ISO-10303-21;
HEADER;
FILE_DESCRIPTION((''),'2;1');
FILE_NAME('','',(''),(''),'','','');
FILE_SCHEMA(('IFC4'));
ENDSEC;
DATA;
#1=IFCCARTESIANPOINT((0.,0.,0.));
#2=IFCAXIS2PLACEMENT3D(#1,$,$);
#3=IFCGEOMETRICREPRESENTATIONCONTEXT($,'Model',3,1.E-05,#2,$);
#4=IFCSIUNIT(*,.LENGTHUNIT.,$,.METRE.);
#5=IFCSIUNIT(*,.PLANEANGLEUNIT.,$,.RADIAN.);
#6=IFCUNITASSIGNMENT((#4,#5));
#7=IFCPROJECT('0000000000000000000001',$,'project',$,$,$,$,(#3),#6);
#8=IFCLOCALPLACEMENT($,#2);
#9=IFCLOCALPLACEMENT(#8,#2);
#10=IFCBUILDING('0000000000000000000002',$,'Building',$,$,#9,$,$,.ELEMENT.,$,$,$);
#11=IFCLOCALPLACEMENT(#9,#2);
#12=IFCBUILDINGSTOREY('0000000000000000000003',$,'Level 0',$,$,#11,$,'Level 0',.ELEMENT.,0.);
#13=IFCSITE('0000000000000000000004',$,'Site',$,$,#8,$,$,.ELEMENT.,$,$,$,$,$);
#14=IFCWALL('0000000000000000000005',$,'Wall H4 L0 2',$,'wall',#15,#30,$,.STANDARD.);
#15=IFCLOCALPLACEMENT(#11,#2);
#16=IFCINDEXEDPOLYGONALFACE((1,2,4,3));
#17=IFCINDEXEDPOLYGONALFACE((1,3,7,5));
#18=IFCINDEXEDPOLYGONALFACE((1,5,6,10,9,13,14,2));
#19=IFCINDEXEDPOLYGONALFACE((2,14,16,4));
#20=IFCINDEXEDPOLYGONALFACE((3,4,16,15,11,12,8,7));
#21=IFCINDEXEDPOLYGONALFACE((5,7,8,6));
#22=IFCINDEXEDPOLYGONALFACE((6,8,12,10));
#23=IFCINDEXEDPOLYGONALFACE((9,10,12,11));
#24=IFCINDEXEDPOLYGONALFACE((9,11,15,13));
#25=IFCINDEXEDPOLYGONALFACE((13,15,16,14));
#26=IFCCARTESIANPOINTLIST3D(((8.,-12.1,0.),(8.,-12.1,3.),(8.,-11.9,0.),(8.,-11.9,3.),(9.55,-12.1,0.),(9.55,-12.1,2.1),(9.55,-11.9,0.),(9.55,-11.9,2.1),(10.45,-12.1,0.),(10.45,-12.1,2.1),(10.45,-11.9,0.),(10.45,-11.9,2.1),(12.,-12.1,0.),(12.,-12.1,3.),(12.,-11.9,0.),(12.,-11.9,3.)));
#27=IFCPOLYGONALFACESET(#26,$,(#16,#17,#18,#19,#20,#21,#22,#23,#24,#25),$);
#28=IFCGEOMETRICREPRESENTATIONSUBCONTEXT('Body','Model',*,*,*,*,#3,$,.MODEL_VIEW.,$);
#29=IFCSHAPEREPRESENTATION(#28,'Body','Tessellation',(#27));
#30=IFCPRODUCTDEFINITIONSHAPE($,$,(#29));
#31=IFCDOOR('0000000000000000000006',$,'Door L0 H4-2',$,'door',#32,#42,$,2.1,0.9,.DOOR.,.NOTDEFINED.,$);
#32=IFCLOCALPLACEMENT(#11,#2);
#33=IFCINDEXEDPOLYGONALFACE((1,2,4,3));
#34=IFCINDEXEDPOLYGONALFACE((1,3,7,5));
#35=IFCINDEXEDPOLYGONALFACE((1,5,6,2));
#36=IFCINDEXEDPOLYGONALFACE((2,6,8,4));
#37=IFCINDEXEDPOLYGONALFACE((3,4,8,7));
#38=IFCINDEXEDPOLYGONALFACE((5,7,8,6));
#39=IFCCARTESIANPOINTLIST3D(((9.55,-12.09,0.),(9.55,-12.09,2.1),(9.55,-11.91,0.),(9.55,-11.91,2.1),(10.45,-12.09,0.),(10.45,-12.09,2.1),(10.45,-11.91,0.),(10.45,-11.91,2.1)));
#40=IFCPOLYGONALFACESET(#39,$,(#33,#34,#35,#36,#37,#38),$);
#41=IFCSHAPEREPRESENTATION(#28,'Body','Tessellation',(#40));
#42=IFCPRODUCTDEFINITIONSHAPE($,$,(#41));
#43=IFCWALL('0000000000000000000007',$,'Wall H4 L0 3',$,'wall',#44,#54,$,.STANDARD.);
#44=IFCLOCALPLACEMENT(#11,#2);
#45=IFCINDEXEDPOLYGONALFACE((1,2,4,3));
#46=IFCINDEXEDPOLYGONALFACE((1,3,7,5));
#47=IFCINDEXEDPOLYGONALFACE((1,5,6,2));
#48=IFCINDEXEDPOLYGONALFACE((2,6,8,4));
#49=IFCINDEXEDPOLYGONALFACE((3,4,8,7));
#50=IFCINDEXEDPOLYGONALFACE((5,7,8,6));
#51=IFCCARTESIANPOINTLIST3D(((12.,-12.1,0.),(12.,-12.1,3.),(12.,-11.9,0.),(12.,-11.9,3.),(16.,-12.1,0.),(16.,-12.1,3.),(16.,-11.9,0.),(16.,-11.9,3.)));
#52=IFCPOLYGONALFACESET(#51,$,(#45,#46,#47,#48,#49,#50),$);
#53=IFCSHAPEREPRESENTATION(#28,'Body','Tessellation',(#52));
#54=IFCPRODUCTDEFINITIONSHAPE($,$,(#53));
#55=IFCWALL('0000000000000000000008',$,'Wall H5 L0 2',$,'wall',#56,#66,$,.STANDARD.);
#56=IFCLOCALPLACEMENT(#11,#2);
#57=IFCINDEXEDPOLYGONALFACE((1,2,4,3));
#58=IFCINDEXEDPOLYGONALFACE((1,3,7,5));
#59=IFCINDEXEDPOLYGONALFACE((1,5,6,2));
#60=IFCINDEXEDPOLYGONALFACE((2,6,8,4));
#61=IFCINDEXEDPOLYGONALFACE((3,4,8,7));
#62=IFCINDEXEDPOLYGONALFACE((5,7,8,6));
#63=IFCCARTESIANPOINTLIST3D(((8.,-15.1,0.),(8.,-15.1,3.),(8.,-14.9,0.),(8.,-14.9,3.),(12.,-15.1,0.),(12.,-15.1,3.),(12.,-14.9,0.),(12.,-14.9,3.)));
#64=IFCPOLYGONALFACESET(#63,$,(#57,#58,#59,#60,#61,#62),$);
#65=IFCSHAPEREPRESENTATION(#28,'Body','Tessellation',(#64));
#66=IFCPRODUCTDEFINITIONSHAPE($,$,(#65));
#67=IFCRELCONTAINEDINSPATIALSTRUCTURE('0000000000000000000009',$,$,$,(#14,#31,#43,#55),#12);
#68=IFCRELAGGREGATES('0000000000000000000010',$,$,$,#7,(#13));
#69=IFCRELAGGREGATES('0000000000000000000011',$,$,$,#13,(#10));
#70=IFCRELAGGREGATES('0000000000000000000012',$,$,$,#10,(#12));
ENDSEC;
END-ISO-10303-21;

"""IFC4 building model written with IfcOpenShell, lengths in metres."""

from ifc_helpers import new_model, si_unit, frame, frame_2d, origin, origin_2d, place, context, subcontext, project, spatial, rectangle, extrude, element, fill, save


model = new_model("IFC4")

# Units and contexts
model_context = context("Model", 3, precision=1e-05, world=origin())
body_context = subcontext(model_context, "Body", "Model", "MODEL_VIEW")
ifc_project = project(units=[si_unit("LENGTHUNIT", "METRE"), si_unit("PLANEANGLEUNIT", "RADIAN")], contexts=[model_context])

# Site, building, storey
site_placement = place(None, origin())
site = spatial("IfcSite", under=ifc_project, at=site_placement, Name="Site", CompositionType="ELEMENT")
building_placement = place(site_placement, origin())
building = spatial("IfcBuilding", under=site, at=building_placement, Name="Building", CompositionType="ELEMENT")
storey_placement = place(building_placement, origin())
storey = spatial("IfcBuildingStorey", under=building, at=storey_placement, Name="Level 0", LongName="Level 0", CompositionType="ELEMENT", Elevation=0.0)

# Wall, opening, door
wall_1_placement = place(storey_placement, frame((8.0, -12.0, 0.0), z_axis=(0.0, 0.0, 1.0), x_axis=(1.0, 0.0, 0.0)))
wall_1 = element("IfcWall", 1, at=wall_1_placement, inside=storey, Name="Wall H4 L0 2", ObjectType="wall", PredefinedType="STANDARD", context=body_context, shape_type="SweptSolid", body=[
    extrude(rectangle(XDim=4.0, YDim=0.2, at=frame_2d((2.0, 0.0))), origin(), (0.0, 0.0, 1.0), 3.0),
])
opening_1_placement = place(storey_placement, frame((10.0, -12.0, 0.0), z_axis=(0.0, 0.0, 1.0), x_axis=(1.0, 0.0, 0.0)))
opening_1 = element("IfcOpeningElement", 2, at=opening_1_placement, cuts=wall_1, ObjectType="Opening", PredefinedType="OPENING", context=body_context, shape_type="SweptSolid", body=[
    extrude(rectangle(XDim=0.9, YDim=0.22, at=origin_2d()), origin(), (0.0, 0.0, 1.0), 2.1),
])
door_1_placement = place(storey_placement, frame((10.0, -12.0, 0.0), z_axis=(0.0, 0.0, 1.0), x_axis=(1.0, 0.0, 0.0)))
door_1 = element("IfcDoor", 3, at=door_1_placement, inside=storey, Name="Door L0 H4-2", ObjectType="door", OperationType="NOTDEFINED", OverallHeight=2.1, OverallWidth=0.9, PredefinedType="DOOR", context=body_context, shape_type="SweptSolid", body=[
    extrude(rectangle(XDim=0.9, YDim=0.18, at=origin_2d()), origin(), (0.0, 0.0, 1.0), 2.1),
])
fill(opening_1, door_1)

# Walls
for number, where, z_axis, x_axis, name in (
    (4, (12.0, -12.0, 0.0), (0.0, 0.0, 1.0), (1.0, 0.0, 0.0), "Wall H4 L0 3"),
    (5, (8.0, -15.0, 0.0), (0.0, 0.0, 1.0), (1.0, 0.0, 0.0), "Wall H5 L0 2"),
):
    element("IfcWall", number, at=place(storey_placement, frame(where, z_axis=z_axis, x_axis=x_axis)), inside=storey, Name=name, ObjectType="wall", PredefinedType="STANDARD", context=body_context, shape_type="SweptSolid", body=[
        extrude(rectangle(XDim=4.0, YDim=0.2, at=frame_2d((2.0, 0.0))), origin(), (0.0, 0.0, 1.0), 3.0),
    ])

save(model, "model.ifc")
